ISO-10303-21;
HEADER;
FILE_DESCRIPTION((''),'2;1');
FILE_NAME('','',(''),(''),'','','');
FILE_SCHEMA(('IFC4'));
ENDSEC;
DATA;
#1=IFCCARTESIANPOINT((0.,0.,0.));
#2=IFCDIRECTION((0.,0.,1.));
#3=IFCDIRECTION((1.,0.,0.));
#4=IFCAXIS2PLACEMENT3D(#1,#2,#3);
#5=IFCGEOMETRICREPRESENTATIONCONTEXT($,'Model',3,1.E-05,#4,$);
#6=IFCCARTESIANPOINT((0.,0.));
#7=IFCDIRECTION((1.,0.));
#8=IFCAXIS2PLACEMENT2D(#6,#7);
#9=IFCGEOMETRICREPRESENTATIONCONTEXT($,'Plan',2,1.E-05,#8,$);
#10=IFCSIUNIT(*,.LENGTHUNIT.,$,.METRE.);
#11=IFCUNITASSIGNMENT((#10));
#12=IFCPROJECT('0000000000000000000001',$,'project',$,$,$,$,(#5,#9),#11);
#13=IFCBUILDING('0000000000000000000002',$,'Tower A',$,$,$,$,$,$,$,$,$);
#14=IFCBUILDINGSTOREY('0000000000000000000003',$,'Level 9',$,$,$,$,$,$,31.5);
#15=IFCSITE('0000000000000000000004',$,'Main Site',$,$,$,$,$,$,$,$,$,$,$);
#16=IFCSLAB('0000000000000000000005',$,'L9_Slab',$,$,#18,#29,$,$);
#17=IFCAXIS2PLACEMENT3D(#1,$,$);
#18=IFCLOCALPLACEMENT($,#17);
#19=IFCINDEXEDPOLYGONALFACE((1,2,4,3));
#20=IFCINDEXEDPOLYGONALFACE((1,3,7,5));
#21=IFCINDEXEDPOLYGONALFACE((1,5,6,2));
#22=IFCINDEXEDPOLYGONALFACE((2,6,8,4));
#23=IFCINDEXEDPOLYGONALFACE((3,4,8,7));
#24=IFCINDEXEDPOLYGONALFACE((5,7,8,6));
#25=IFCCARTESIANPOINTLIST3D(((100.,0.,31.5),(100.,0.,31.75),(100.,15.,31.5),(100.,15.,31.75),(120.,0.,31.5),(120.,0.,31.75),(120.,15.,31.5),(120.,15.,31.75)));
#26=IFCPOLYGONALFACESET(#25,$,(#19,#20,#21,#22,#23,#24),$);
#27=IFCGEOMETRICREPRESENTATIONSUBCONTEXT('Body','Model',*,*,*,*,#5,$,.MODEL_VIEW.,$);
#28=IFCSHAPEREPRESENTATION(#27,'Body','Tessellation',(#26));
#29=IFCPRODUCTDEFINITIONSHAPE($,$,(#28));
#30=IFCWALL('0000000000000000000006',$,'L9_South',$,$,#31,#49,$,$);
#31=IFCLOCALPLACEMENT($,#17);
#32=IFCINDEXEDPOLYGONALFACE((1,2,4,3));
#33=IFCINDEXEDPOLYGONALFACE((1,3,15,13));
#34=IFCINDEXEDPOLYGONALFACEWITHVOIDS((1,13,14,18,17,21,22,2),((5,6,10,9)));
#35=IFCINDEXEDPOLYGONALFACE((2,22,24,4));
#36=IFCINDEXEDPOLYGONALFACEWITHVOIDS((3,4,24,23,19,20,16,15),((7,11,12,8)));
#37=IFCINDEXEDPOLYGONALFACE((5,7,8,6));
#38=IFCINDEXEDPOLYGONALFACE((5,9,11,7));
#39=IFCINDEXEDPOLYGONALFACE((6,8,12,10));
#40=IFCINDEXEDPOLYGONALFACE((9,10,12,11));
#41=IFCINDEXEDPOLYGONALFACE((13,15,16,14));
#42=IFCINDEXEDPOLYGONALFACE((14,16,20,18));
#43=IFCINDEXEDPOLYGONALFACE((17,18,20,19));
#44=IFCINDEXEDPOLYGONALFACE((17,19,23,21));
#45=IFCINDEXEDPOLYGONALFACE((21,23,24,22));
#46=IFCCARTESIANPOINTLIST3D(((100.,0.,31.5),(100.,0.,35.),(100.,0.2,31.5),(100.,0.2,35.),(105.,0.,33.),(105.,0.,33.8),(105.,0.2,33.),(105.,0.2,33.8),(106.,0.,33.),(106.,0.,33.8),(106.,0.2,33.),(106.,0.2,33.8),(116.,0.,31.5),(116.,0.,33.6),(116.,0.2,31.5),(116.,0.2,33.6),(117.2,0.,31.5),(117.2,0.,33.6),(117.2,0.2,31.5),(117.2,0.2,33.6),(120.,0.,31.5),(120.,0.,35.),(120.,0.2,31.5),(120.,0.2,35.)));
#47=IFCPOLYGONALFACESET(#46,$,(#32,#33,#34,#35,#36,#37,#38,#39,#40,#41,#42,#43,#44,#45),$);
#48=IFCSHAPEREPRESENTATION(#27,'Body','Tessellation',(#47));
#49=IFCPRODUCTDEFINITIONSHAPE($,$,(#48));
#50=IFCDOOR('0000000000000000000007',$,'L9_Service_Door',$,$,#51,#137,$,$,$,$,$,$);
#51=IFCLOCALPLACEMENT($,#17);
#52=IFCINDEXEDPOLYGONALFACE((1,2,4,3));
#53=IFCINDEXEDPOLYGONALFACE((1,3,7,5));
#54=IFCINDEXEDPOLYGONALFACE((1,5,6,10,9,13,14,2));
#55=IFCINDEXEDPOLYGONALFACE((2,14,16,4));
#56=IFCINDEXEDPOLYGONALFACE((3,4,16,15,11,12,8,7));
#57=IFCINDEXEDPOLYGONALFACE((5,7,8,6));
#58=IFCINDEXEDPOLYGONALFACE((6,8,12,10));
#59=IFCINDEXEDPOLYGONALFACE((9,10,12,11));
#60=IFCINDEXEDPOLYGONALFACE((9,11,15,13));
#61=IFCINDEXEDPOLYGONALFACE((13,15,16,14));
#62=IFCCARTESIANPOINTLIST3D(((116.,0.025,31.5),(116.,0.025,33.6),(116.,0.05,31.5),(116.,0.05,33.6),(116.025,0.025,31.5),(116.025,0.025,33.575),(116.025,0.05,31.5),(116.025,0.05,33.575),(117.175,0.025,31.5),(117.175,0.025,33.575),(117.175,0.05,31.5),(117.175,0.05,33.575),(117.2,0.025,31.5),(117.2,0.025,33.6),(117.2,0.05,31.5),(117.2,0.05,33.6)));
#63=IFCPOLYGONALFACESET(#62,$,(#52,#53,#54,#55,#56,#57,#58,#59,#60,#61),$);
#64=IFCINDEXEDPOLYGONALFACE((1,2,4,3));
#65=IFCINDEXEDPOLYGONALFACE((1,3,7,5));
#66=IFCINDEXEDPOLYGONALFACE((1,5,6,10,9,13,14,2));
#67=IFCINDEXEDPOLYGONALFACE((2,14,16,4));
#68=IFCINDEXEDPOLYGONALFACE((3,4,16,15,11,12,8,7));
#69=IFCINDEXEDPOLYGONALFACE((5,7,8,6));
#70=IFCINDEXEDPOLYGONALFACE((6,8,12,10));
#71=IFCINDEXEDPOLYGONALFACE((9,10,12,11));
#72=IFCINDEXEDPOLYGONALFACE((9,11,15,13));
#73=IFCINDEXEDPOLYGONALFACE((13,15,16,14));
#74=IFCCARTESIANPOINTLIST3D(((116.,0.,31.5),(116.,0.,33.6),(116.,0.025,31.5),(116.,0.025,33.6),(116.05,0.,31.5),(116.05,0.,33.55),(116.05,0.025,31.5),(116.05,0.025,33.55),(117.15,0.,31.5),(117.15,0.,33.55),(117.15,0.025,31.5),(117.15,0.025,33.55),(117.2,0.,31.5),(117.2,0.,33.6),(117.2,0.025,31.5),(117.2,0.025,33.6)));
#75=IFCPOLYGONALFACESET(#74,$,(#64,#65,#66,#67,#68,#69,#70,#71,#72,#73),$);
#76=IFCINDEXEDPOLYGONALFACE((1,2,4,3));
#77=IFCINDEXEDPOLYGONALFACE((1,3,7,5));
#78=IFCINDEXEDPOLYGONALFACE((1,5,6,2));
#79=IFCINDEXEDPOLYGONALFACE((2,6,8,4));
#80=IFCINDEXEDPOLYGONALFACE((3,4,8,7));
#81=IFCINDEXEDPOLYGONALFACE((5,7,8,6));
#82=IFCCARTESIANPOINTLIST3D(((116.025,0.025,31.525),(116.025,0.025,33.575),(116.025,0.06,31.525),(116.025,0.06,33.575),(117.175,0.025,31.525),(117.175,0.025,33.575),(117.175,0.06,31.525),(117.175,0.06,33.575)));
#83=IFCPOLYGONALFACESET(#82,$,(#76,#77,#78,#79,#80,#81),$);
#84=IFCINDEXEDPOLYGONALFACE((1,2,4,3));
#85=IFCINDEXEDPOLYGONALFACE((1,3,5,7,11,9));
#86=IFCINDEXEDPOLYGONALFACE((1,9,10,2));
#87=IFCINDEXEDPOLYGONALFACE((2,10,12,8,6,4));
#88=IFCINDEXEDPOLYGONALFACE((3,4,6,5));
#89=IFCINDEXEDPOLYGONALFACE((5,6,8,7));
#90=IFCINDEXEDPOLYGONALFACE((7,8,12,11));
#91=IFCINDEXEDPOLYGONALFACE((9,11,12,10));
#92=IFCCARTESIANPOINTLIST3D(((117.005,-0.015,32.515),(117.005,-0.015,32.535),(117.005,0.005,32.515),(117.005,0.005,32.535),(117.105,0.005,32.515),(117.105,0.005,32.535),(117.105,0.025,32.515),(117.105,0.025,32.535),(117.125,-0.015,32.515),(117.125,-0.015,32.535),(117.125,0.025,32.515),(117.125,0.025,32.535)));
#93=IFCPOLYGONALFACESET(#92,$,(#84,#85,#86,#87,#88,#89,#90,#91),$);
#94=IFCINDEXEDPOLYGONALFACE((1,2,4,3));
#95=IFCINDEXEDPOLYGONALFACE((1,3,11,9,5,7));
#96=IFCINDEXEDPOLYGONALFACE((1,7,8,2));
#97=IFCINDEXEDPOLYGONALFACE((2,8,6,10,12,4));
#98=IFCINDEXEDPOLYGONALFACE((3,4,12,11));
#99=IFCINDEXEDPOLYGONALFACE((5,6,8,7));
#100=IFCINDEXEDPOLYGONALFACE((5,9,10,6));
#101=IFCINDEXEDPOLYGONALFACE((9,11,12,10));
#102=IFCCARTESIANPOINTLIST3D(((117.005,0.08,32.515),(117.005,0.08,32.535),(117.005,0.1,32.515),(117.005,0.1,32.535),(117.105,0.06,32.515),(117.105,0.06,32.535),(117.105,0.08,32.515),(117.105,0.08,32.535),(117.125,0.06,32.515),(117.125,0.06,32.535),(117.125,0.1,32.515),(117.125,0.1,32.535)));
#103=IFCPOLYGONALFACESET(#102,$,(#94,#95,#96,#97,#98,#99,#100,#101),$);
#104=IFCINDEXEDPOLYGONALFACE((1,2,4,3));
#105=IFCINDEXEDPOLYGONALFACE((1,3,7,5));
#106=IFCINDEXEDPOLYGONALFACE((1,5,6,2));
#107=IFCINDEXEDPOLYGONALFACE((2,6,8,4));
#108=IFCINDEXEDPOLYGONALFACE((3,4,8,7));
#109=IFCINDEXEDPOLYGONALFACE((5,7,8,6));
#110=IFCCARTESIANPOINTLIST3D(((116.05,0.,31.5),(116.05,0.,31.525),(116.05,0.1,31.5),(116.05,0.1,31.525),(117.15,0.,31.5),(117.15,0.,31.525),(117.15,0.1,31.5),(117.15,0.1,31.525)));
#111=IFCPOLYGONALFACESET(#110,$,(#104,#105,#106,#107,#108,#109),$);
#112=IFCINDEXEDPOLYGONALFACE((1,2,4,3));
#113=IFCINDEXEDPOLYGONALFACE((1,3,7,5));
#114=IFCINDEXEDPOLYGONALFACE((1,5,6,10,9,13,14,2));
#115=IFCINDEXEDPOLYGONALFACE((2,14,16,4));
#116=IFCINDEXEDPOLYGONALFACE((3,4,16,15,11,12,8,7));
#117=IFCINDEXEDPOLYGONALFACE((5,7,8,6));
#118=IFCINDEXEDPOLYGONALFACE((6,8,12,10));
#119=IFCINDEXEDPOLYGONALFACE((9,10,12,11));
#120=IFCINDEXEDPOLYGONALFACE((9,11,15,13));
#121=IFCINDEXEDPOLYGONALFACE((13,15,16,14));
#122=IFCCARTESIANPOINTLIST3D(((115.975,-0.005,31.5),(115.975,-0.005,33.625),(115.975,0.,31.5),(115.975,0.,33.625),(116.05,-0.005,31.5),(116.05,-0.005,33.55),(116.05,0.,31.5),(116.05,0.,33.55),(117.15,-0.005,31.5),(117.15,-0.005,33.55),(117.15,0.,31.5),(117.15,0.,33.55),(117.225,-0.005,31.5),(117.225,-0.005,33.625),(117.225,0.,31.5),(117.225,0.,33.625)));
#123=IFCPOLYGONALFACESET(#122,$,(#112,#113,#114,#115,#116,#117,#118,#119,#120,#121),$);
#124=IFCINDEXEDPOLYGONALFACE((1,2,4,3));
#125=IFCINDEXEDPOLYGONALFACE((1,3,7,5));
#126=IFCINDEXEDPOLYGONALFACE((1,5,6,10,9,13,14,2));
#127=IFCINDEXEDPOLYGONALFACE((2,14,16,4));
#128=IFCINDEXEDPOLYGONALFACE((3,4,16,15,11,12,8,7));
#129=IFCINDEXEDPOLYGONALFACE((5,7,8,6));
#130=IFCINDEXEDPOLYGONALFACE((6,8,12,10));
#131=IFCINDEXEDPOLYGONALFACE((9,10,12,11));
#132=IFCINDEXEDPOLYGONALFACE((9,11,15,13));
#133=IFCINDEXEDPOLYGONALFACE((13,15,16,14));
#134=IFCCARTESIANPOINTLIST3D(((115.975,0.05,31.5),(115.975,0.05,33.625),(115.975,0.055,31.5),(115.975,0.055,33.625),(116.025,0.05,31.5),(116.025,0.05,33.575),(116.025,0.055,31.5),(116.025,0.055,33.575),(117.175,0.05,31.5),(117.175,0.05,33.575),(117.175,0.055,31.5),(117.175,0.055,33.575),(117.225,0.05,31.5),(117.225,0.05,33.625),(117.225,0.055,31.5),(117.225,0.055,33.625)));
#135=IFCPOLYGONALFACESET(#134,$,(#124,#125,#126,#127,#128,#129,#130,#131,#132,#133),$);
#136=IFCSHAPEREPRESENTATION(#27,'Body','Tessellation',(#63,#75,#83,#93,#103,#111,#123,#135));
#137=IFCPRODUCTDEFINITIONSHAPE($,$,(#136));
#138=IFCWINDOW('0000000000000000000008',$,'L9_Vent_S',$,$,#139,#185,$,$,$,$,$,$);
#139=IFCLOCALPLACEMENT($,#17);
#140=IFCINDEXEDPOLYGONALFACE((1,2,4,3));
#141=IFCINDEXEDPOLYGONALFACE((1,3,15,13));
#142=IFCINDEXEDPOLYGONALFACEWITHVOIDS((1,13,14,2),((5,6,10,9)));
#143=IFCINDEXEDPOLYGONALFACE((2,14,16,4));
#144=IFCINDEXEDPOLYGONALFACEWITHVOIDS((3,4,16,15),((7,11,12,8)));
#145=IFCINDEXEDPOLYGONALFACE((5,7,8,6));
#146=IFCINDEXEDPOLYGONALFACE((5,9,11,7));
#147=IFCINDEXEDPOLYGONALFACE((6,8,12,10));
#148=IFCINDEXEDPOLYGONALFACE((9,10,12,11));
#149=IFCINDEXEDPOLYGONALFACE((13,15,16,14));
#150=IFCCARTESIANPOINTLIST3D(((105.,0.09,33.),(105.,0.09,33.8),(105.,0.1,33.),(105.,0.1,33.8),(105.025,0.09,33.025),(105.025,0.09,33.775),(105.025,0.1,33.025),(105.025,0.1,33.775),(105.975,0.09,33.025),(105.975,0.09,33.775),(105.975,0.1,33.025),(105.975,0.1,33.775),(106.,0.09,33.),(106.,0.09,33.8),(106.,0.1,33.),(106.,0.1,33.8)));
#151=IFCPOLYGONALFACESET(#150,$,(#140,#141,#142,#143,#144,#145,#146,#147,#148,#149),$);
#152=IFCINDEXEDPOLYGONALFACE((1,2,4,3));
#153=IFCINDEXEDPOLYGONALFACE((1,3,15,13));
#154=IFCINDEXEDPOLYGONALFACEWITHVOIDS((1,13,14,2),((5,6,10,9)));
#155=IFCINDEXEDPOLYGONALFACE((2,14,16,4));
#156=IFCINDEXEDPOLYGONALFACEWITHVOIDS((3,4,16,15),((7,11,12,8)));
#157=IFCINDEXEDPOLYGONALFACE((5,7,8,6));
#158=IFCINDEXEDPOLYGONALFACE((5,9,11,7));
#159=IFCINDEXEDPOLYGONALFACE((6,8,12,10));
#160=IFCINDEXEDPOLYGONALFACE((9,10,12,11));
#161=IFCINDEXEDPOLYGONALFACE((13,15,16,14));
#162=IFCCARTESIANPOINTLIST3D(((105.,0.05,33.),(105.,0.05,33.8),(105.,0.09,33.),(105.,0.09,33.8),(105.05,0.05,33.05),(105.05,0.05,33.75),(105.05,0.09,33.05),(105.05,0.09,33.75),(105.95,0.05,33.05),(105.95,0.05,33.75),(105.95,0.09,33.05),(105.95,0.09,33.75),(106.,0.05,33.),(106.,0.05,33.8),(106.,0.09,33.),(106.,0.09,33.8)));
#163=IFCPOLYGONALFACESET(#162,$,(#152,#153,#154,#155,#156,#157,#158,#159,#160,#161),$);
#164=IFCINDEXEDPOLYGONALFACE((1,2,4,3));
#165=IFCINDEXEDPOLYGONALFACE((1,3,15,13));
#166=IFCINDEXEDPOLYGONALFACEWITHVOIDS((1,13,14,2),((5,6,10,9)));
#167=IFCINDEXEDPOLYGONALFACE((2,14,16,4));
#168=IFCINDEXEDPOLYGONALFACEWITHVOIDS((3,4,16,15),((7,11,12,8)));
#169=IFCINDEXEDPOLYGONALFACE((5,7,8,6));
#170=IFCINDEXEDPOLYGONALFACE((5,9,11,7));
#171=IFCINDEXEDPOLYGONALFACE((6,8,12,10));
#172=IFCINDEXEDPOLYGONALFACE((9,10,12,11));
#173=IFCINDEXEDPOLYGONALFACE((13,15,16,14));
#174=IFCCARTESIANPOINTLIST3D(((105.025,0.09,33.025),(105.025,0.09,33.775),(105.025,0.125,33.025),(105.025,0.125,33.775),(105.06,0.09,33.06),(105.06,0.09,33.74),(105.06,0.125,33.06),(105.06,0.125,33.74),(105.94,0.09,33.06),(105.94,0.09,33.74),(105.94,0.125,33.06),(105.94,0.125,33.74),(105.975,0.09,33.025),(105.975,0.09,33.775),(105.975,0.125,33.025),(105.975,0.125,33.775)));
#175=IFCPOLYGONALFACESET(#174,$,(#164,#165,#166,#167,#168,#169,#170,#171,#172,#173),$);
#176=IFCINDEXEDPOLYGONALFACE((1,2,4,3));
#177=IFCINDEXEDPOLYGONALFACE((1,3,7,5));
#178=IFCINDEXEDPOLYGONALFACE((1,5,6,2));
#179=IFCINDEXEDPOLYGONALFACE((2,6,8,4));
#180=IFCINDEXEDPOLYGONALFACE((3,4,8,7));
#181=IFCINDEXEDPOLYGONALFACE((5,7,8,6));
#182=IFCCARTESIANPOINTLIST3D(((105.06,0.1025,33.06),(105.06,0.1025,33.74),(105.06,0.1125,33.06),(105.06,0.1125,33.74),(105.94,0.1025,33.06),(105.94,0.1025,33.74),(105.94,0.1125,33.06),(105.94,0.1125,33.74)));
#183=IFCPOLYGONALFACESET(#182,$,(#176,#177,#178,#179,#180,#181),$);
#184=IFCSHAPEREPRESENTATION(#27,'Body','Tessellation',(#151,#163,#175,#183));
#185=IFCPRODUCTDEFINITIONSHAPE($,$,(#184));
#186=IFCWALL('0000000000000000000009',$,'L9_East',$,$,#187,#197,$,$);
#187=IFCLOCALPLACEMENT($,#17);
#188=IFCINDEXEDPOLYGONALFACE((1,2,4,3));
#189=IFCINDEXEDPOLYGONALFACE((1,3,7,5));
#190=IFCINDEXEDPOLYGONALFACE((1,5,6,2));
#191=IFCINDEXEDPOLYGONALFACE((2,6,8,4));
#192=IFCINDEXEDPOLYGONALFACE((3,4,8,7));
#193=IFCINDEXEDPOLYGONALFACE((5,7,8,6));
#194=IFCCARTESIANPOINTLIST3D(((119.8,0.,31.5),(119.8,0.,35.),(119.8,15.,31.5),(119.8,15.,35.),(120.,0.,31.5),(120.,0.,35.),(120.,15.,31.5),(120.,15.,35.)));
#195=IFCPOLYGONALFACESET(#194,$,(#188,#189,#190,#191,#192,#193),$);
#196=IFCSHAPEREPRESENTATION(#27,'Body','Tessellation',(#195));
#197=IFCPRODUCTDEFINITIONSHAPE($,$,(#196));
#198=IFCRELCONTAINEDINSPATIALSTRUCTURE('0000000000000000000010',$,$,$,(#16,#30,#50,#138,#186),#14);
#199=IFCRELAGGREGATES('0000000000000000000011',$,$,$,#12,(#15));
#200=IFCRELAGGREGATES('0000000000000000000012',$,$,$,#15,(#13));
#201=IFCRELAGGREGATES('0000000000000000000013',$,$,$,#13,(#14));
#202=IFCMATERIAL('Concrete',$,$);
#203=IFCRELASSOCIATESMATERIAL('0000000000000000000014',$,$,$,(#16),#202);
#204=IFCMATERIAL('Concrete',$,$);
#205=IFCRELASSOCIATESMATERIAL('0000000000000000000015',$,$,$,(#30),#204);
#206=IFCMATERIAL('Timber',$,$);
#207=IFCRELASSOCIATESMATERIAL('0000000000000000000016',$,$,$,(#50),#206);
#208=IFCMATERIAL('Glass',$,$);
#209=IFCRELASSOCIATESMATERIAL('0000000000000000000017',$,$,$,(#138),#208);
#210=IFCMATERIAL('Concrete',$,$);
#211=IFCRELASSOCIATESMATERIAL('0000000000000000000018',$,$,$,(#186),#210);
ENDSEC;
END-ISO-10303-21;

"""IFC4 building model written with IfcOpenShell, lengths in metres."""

from ifc_helpers import new_model, si_unit, frame, origin_with_axes, origin_2d_with_axis, place, context, subcontext, project, spatial, line, indexed_curve, outline, extrude, material, element, fill, save


model = new_model("IFC4")

# Units and contexts
model_context = context("Model", 3, precision=1e-05, world=origin_with_axes())
plan_context = context("Plan", 2, precision=1e-05, world=origin_2d_with_axis())
body_context = subcontext(model_context, "Body", "Model", "MODEL_VIEW")
ifc_project = project(units=[si_unit("LENGTHUNIT", "METRE")], contexts=[model_context, plan_context])

# Site, building, storey
site = spatial("IfcSite", under=ifc_project, Name="Main Site")
building = spatial("IfcBuilding", under=site, Name="Tower A")
storey = spatial("IfcBuildingStorey", under=building, Name="Level 9", Elevation=31.5)

# Slab
ifc_material_1 = material(Name="Concrete")
slab_placement = place(None, frame((100.0, 0.0, 31.5), z_axis=(0.0, 0.0, 1.0), x_axis=(1.0, 0.0, 0.0)))
element("IfcSlab", 1, at=slab_placement, inside=storey, material=ifc_material_1, Name="L9_Slab", context=body_context, shape_type="SweptSolid", body=[
    extrude(outline(indexed_curve([(0.0, 0.0), (20.0, 0.0), (20.0, 15.0), (0.0, 15.0)])), None, (0.0, 0.0, 1.0), 0.25),
])

# Wall, openings, door, window
ifc_material_2 = material(Name="Concrete")
wall_1_placement = place(None, frame((100.0, 0.0, 31.5), z_axis=(0.0, 0.0, 1.0), x_axis=(1.0, 0.0, 0.0)))
wall_1 = element("IfcWall", 2, at=wall_1_placement, inside=storey, material=ifc_material_2, Name="L9_South", context=body_context, shape_type="SweptSolid", body=[
    extrude(outline(indexed_curve([(0.0, 0.0), (0.0, 0.2), (20.0, 0.2), (20.0, 0.0), (0.0, 0.0)], self_intersect=False)), origin_with_axes(), (0.0, 0.0, 1.0), 3.5),
])
opening_1_placement = place(wall_1_placement, frame((16.0, 0.0, 0.0), z_axis=(0.0, 0.0, 1.0), x_axis=(1.0, 0.0, 0.0)))
opening_1 = element("IfcOpeningElement", 3, at=opening_1_placement, cuts=wall_1, context=body_context, shape_type="SweptSolid", body=[
    extrude(outline(indexed_curve([(0.0, 0.0), (0.0, 0.25), (1.2, 0.25), (1.2, 0.0), (0.0, 0.0)], self_intersect=False)), origin_with_axes(), (0.0, 0.0, 1.0), 2.1),
])
opening_2_placement = place(wall_1_placement, frame((5.0, 0.0, 1.5), z_axis=(0.0, 0.0, 1.0), x_axis=(1.0, 0.0, 0.0)))
opening_2 = element("IfcOpeningElement", 4, at=opening_2_placement, cuts=wall_1, context=body_context, shape_type="SweptSolid", body=[
    extrude(outline(indexed_curve([(0.0, 0.0), (0.0, 0.25), (1.0, 0.25), (1.0, 0.0), (0.0, 0.0)], self_intersect=False)), origin_with_axes(), (0.0, 0.0, 1.0), 0.8),
])
ifc_material_3 = material(Name="Timber")
door_placement = place(None, frame((116.0, 0.0, 31.5), z_axis=(0.0, 0.0, 1.0), x_axis=(1.0, 0.0, 0.0)))
door = element("IfcDoor", 5, at=door_placement, inside=storey, material=ifc_material_3, Name="L9_Service_Door", context=body_context, shape_type="SweptSolid", body=[
    extrude(outline(indexed_curve([(0.0, 0.0), (0.0, 2.1), (1.2, 2.1), (1.2, 0.0), (1.175, 0.0), (1.175, 2.075), (0.025, 2.075), (0.025, 0.0)], segments=[line(1, 2, 3, 4, 5, 6, 7, 8, 1)])), frame((0.0, 0.025, 0.0), z_axis=(0.0, -1.0, 0.0), x_axis=(1.0, 0.0, 0.0)), (0.0, 0.0, -1.0), 0.025),
    extrude(outline(indexed_curve([(0.0, 0.0), (0.0, 2.1), (1.2, 2.1), (1.2, 0.0), (1.15, 0.0), (1.15, 2.05), (0.05, 2.05), (0.05, 0.0)], segments=[line(1, 2, 3, 4, 5, 6, 7, 8, 1)])), frame((0.0, 0.0, 0.0), z_axis=(0.0, -1.0, 0.0), x_axis=(1.0, 0.0, 0.0)), (0.0, 0.0, -1.0), 0.025),
    extrude(outline(indexed_curve([(0.0, 0.0), (1.15, 0.0), (1.15, 0.035), (0.0, 0.035)], segments=[line(1, 2, 3, 4, 1)])), frame((0.025, 0.025, 0.025), z_axis=(0.0, 0.0, 1.0), x_axis=(1.0, 0.0, 0.0)), (0.0, 0.0, 1.0), 2.05),
    extrude(outline(indexed_curve([(0.0, 0.0), (0.0, -0.04), (-0.12, -0.04), (-0.12, -0.02), (-0.02, -0.02), (-0.02, 0.0)], segments=[line(1, 2, 3, 4, 5, 6, 1)])), frame((1.125, 0.025, 1.015), z_axis=(0.0, 0.0, 1.0), x_axis=(1.0, 0.0, 0.0)), (0.0, 0.0, 1.0), 0.02),
    extrude(outline(indexed_curve([(0.0, 0.0), (0.0, 0.04), (-0.12, 0.04), (-0.12, 0.02), (-0.02, 0.02), (-0.02, 0.0)], segments=[line(1, 2, 3, 4, 5, 6, 1)])), frame((1.125, 0.06, 1.015), z_axis=(0.0, 0.0, 1.0), x_axis=(1.0, 0.0, 0.0)), (0.0, 0.0, 1.0), 0.02),
    extrude(outline(indexed_curve([(0.0, 0.0), (1.1, 0.0), (1.1, 0.1), (0.0, 0.1)], segments=[line(1, 2, 3, 4, 1)])), frame((0.05, 0.0, 0.0), z_axis=(0.0, 0.0, 1.0), x_axis=(1.0, 0.0, 0.0)), (0.0, 0.0, 1.0), 0.025),
    extrude(outline(indexed_curve([(0.0, 0.0), (0.0, 2.125), (1.25, 2.125), (1.25, 0.0), (1.175, 0.0), (1.175, 2.05), (0.075, 2.05), (0.075, 0.0)], segments=[line(1, 2, 3, 4, 5, 6, 7, 8, 1)])), frame((-0.025, -0.005, 0.0), z_axis=(0.0, -1.0, 0.0), x_axis=(1.0, 0.0, 0.0)), (0.0, 0.0, -1.0), 0.005),
    extrude(outline(indexed_curve([(0.0, 0.0), (0.0, 2.125), (1.25, 2.125), (1.25, 0.0), (1.2, 0.0), (1.2, 2.075), (0.05, 2.075), (0.05, 0.0)], segments=[line(1, 2, 3, 4, 5, 6, 7, 8, 1)])), frame((-0.025, 0.05, 0.0), z_axis=(0.0, -1.0, 0.0), x_axis=(1.0, 0.0, 0.0)), (0.0, 0.0, -1.0), 0.005),
])
fill(opening_1, door)
ifc_material_4 = material(Name="Glass")
window_1_placement = place(None, frame((105.0, 0.0, 33.0), z_axis=(0.0, 0.0, 1.0), x_axis=(1.0, 0.0, 0.0)))
window_1 = element("IfcWindow", 6, at=window_1_placement, inside=storey, material=ifc_material_4, Name="L9_Vent_S", context=body_context, shape_type="SweptSolid", body=[
    extrude(outline(indexed_curve([(0.0, 0.0), (1.0, 0.0), (1.0, 0.8), (0.0, 0.8)], segments=[line(1, 2, 3, 4, 1)]), holes=[indexed_curve([(0.025, 0.025), (0.975, 0.025), (0.975, 0.775), (0.025, 0.775)], segments=[line(1, 2, 3, 4, 1)])]), frame((0.0, 0.09, 0.0), z_axis=(0.0, -1.0, 0.0), x_axis=(1.0, 0.0, 0.0)), (0.0, 0.0, -1.0), 0.01),
    extrude(outline(indexed_curve([(0.0, 0.0), (1.0, 0.0), (1.0, 0.8), (0.0, 0.8)], segments=[line(1, 2, 3, 4, 1)]), holes=[indexed_curve([(0.05, 0.05), (0.95, 0.05), (0.95, 0.75), (0.05, 0.75)], segments=[line(1, 2, 3, 4, 1)])]), frame((0.0, 0.05, 0.0), z_axis=(0.0, -1.0, 0.0), x_axis=(1.0, 0.0, 0.0)), (0.0, 0.0, -1.0), 0.04),
    extrude(outline(indexed_curve([(0.0, 0.0), (0.95, 0.0), (0.95, 0.75), (0.0, 0.75)], segments=[line(1, 2, 3, 4, 1)]), holes=[indexed_curve([(0.035, 0.035), (0.915, 0.035), (0.915, 0.715), (0.035, 0.715)], segments=[line(1, 2, 3, 4, 1)])]), frame((0.025, 0.09, 0.025), z_axis=(0.0, -1.0, 0.0), x_axis=(1.0, 0.0, 0.0)), (0.0, 0.0, -1.0), 0.035),
    extrude(outline(indexed_curve([(0.035, 0.035), (0.915, 0.035), (0.915, 0.715), (0.035, 0.715)], segments=[line(1, 2, 3, 4, 1)])), frame((0.025, 0.1025, 0.025), z_axis=(0.0, -1.0, 0.0), x_axis=(1.0, 0.0, 0.0)), (0.0, 0.0, -1.0), 0.01),
])
fill(opening_2, window_1)

# Wall
ifc_material_5 = material(Name="Concrete")
wall_2_placement = place(None, frame((120.0, 0.0, 31.5), z_axis=(0.0, 0.0, 1.0), x_axis=(0.0, 1.0, 0.0)))
element("IfcWall", 7, at=wall_2_placement, inside=storey, material=ifc_material_5, Name="L9_East", context=body_context, shape_type="SweptSolid", body=[
    extrude(outline(indexed_curve([(0.0, 0.0), (0.0, 0.2), (15.0, 0.2), (15.0, 0.0), (0.0, 0.0)], self_intersect=False)), origin_with_axes(), (0.0, 0.0, 1.0), 3.5),
])

save(model, "model.ifc")
